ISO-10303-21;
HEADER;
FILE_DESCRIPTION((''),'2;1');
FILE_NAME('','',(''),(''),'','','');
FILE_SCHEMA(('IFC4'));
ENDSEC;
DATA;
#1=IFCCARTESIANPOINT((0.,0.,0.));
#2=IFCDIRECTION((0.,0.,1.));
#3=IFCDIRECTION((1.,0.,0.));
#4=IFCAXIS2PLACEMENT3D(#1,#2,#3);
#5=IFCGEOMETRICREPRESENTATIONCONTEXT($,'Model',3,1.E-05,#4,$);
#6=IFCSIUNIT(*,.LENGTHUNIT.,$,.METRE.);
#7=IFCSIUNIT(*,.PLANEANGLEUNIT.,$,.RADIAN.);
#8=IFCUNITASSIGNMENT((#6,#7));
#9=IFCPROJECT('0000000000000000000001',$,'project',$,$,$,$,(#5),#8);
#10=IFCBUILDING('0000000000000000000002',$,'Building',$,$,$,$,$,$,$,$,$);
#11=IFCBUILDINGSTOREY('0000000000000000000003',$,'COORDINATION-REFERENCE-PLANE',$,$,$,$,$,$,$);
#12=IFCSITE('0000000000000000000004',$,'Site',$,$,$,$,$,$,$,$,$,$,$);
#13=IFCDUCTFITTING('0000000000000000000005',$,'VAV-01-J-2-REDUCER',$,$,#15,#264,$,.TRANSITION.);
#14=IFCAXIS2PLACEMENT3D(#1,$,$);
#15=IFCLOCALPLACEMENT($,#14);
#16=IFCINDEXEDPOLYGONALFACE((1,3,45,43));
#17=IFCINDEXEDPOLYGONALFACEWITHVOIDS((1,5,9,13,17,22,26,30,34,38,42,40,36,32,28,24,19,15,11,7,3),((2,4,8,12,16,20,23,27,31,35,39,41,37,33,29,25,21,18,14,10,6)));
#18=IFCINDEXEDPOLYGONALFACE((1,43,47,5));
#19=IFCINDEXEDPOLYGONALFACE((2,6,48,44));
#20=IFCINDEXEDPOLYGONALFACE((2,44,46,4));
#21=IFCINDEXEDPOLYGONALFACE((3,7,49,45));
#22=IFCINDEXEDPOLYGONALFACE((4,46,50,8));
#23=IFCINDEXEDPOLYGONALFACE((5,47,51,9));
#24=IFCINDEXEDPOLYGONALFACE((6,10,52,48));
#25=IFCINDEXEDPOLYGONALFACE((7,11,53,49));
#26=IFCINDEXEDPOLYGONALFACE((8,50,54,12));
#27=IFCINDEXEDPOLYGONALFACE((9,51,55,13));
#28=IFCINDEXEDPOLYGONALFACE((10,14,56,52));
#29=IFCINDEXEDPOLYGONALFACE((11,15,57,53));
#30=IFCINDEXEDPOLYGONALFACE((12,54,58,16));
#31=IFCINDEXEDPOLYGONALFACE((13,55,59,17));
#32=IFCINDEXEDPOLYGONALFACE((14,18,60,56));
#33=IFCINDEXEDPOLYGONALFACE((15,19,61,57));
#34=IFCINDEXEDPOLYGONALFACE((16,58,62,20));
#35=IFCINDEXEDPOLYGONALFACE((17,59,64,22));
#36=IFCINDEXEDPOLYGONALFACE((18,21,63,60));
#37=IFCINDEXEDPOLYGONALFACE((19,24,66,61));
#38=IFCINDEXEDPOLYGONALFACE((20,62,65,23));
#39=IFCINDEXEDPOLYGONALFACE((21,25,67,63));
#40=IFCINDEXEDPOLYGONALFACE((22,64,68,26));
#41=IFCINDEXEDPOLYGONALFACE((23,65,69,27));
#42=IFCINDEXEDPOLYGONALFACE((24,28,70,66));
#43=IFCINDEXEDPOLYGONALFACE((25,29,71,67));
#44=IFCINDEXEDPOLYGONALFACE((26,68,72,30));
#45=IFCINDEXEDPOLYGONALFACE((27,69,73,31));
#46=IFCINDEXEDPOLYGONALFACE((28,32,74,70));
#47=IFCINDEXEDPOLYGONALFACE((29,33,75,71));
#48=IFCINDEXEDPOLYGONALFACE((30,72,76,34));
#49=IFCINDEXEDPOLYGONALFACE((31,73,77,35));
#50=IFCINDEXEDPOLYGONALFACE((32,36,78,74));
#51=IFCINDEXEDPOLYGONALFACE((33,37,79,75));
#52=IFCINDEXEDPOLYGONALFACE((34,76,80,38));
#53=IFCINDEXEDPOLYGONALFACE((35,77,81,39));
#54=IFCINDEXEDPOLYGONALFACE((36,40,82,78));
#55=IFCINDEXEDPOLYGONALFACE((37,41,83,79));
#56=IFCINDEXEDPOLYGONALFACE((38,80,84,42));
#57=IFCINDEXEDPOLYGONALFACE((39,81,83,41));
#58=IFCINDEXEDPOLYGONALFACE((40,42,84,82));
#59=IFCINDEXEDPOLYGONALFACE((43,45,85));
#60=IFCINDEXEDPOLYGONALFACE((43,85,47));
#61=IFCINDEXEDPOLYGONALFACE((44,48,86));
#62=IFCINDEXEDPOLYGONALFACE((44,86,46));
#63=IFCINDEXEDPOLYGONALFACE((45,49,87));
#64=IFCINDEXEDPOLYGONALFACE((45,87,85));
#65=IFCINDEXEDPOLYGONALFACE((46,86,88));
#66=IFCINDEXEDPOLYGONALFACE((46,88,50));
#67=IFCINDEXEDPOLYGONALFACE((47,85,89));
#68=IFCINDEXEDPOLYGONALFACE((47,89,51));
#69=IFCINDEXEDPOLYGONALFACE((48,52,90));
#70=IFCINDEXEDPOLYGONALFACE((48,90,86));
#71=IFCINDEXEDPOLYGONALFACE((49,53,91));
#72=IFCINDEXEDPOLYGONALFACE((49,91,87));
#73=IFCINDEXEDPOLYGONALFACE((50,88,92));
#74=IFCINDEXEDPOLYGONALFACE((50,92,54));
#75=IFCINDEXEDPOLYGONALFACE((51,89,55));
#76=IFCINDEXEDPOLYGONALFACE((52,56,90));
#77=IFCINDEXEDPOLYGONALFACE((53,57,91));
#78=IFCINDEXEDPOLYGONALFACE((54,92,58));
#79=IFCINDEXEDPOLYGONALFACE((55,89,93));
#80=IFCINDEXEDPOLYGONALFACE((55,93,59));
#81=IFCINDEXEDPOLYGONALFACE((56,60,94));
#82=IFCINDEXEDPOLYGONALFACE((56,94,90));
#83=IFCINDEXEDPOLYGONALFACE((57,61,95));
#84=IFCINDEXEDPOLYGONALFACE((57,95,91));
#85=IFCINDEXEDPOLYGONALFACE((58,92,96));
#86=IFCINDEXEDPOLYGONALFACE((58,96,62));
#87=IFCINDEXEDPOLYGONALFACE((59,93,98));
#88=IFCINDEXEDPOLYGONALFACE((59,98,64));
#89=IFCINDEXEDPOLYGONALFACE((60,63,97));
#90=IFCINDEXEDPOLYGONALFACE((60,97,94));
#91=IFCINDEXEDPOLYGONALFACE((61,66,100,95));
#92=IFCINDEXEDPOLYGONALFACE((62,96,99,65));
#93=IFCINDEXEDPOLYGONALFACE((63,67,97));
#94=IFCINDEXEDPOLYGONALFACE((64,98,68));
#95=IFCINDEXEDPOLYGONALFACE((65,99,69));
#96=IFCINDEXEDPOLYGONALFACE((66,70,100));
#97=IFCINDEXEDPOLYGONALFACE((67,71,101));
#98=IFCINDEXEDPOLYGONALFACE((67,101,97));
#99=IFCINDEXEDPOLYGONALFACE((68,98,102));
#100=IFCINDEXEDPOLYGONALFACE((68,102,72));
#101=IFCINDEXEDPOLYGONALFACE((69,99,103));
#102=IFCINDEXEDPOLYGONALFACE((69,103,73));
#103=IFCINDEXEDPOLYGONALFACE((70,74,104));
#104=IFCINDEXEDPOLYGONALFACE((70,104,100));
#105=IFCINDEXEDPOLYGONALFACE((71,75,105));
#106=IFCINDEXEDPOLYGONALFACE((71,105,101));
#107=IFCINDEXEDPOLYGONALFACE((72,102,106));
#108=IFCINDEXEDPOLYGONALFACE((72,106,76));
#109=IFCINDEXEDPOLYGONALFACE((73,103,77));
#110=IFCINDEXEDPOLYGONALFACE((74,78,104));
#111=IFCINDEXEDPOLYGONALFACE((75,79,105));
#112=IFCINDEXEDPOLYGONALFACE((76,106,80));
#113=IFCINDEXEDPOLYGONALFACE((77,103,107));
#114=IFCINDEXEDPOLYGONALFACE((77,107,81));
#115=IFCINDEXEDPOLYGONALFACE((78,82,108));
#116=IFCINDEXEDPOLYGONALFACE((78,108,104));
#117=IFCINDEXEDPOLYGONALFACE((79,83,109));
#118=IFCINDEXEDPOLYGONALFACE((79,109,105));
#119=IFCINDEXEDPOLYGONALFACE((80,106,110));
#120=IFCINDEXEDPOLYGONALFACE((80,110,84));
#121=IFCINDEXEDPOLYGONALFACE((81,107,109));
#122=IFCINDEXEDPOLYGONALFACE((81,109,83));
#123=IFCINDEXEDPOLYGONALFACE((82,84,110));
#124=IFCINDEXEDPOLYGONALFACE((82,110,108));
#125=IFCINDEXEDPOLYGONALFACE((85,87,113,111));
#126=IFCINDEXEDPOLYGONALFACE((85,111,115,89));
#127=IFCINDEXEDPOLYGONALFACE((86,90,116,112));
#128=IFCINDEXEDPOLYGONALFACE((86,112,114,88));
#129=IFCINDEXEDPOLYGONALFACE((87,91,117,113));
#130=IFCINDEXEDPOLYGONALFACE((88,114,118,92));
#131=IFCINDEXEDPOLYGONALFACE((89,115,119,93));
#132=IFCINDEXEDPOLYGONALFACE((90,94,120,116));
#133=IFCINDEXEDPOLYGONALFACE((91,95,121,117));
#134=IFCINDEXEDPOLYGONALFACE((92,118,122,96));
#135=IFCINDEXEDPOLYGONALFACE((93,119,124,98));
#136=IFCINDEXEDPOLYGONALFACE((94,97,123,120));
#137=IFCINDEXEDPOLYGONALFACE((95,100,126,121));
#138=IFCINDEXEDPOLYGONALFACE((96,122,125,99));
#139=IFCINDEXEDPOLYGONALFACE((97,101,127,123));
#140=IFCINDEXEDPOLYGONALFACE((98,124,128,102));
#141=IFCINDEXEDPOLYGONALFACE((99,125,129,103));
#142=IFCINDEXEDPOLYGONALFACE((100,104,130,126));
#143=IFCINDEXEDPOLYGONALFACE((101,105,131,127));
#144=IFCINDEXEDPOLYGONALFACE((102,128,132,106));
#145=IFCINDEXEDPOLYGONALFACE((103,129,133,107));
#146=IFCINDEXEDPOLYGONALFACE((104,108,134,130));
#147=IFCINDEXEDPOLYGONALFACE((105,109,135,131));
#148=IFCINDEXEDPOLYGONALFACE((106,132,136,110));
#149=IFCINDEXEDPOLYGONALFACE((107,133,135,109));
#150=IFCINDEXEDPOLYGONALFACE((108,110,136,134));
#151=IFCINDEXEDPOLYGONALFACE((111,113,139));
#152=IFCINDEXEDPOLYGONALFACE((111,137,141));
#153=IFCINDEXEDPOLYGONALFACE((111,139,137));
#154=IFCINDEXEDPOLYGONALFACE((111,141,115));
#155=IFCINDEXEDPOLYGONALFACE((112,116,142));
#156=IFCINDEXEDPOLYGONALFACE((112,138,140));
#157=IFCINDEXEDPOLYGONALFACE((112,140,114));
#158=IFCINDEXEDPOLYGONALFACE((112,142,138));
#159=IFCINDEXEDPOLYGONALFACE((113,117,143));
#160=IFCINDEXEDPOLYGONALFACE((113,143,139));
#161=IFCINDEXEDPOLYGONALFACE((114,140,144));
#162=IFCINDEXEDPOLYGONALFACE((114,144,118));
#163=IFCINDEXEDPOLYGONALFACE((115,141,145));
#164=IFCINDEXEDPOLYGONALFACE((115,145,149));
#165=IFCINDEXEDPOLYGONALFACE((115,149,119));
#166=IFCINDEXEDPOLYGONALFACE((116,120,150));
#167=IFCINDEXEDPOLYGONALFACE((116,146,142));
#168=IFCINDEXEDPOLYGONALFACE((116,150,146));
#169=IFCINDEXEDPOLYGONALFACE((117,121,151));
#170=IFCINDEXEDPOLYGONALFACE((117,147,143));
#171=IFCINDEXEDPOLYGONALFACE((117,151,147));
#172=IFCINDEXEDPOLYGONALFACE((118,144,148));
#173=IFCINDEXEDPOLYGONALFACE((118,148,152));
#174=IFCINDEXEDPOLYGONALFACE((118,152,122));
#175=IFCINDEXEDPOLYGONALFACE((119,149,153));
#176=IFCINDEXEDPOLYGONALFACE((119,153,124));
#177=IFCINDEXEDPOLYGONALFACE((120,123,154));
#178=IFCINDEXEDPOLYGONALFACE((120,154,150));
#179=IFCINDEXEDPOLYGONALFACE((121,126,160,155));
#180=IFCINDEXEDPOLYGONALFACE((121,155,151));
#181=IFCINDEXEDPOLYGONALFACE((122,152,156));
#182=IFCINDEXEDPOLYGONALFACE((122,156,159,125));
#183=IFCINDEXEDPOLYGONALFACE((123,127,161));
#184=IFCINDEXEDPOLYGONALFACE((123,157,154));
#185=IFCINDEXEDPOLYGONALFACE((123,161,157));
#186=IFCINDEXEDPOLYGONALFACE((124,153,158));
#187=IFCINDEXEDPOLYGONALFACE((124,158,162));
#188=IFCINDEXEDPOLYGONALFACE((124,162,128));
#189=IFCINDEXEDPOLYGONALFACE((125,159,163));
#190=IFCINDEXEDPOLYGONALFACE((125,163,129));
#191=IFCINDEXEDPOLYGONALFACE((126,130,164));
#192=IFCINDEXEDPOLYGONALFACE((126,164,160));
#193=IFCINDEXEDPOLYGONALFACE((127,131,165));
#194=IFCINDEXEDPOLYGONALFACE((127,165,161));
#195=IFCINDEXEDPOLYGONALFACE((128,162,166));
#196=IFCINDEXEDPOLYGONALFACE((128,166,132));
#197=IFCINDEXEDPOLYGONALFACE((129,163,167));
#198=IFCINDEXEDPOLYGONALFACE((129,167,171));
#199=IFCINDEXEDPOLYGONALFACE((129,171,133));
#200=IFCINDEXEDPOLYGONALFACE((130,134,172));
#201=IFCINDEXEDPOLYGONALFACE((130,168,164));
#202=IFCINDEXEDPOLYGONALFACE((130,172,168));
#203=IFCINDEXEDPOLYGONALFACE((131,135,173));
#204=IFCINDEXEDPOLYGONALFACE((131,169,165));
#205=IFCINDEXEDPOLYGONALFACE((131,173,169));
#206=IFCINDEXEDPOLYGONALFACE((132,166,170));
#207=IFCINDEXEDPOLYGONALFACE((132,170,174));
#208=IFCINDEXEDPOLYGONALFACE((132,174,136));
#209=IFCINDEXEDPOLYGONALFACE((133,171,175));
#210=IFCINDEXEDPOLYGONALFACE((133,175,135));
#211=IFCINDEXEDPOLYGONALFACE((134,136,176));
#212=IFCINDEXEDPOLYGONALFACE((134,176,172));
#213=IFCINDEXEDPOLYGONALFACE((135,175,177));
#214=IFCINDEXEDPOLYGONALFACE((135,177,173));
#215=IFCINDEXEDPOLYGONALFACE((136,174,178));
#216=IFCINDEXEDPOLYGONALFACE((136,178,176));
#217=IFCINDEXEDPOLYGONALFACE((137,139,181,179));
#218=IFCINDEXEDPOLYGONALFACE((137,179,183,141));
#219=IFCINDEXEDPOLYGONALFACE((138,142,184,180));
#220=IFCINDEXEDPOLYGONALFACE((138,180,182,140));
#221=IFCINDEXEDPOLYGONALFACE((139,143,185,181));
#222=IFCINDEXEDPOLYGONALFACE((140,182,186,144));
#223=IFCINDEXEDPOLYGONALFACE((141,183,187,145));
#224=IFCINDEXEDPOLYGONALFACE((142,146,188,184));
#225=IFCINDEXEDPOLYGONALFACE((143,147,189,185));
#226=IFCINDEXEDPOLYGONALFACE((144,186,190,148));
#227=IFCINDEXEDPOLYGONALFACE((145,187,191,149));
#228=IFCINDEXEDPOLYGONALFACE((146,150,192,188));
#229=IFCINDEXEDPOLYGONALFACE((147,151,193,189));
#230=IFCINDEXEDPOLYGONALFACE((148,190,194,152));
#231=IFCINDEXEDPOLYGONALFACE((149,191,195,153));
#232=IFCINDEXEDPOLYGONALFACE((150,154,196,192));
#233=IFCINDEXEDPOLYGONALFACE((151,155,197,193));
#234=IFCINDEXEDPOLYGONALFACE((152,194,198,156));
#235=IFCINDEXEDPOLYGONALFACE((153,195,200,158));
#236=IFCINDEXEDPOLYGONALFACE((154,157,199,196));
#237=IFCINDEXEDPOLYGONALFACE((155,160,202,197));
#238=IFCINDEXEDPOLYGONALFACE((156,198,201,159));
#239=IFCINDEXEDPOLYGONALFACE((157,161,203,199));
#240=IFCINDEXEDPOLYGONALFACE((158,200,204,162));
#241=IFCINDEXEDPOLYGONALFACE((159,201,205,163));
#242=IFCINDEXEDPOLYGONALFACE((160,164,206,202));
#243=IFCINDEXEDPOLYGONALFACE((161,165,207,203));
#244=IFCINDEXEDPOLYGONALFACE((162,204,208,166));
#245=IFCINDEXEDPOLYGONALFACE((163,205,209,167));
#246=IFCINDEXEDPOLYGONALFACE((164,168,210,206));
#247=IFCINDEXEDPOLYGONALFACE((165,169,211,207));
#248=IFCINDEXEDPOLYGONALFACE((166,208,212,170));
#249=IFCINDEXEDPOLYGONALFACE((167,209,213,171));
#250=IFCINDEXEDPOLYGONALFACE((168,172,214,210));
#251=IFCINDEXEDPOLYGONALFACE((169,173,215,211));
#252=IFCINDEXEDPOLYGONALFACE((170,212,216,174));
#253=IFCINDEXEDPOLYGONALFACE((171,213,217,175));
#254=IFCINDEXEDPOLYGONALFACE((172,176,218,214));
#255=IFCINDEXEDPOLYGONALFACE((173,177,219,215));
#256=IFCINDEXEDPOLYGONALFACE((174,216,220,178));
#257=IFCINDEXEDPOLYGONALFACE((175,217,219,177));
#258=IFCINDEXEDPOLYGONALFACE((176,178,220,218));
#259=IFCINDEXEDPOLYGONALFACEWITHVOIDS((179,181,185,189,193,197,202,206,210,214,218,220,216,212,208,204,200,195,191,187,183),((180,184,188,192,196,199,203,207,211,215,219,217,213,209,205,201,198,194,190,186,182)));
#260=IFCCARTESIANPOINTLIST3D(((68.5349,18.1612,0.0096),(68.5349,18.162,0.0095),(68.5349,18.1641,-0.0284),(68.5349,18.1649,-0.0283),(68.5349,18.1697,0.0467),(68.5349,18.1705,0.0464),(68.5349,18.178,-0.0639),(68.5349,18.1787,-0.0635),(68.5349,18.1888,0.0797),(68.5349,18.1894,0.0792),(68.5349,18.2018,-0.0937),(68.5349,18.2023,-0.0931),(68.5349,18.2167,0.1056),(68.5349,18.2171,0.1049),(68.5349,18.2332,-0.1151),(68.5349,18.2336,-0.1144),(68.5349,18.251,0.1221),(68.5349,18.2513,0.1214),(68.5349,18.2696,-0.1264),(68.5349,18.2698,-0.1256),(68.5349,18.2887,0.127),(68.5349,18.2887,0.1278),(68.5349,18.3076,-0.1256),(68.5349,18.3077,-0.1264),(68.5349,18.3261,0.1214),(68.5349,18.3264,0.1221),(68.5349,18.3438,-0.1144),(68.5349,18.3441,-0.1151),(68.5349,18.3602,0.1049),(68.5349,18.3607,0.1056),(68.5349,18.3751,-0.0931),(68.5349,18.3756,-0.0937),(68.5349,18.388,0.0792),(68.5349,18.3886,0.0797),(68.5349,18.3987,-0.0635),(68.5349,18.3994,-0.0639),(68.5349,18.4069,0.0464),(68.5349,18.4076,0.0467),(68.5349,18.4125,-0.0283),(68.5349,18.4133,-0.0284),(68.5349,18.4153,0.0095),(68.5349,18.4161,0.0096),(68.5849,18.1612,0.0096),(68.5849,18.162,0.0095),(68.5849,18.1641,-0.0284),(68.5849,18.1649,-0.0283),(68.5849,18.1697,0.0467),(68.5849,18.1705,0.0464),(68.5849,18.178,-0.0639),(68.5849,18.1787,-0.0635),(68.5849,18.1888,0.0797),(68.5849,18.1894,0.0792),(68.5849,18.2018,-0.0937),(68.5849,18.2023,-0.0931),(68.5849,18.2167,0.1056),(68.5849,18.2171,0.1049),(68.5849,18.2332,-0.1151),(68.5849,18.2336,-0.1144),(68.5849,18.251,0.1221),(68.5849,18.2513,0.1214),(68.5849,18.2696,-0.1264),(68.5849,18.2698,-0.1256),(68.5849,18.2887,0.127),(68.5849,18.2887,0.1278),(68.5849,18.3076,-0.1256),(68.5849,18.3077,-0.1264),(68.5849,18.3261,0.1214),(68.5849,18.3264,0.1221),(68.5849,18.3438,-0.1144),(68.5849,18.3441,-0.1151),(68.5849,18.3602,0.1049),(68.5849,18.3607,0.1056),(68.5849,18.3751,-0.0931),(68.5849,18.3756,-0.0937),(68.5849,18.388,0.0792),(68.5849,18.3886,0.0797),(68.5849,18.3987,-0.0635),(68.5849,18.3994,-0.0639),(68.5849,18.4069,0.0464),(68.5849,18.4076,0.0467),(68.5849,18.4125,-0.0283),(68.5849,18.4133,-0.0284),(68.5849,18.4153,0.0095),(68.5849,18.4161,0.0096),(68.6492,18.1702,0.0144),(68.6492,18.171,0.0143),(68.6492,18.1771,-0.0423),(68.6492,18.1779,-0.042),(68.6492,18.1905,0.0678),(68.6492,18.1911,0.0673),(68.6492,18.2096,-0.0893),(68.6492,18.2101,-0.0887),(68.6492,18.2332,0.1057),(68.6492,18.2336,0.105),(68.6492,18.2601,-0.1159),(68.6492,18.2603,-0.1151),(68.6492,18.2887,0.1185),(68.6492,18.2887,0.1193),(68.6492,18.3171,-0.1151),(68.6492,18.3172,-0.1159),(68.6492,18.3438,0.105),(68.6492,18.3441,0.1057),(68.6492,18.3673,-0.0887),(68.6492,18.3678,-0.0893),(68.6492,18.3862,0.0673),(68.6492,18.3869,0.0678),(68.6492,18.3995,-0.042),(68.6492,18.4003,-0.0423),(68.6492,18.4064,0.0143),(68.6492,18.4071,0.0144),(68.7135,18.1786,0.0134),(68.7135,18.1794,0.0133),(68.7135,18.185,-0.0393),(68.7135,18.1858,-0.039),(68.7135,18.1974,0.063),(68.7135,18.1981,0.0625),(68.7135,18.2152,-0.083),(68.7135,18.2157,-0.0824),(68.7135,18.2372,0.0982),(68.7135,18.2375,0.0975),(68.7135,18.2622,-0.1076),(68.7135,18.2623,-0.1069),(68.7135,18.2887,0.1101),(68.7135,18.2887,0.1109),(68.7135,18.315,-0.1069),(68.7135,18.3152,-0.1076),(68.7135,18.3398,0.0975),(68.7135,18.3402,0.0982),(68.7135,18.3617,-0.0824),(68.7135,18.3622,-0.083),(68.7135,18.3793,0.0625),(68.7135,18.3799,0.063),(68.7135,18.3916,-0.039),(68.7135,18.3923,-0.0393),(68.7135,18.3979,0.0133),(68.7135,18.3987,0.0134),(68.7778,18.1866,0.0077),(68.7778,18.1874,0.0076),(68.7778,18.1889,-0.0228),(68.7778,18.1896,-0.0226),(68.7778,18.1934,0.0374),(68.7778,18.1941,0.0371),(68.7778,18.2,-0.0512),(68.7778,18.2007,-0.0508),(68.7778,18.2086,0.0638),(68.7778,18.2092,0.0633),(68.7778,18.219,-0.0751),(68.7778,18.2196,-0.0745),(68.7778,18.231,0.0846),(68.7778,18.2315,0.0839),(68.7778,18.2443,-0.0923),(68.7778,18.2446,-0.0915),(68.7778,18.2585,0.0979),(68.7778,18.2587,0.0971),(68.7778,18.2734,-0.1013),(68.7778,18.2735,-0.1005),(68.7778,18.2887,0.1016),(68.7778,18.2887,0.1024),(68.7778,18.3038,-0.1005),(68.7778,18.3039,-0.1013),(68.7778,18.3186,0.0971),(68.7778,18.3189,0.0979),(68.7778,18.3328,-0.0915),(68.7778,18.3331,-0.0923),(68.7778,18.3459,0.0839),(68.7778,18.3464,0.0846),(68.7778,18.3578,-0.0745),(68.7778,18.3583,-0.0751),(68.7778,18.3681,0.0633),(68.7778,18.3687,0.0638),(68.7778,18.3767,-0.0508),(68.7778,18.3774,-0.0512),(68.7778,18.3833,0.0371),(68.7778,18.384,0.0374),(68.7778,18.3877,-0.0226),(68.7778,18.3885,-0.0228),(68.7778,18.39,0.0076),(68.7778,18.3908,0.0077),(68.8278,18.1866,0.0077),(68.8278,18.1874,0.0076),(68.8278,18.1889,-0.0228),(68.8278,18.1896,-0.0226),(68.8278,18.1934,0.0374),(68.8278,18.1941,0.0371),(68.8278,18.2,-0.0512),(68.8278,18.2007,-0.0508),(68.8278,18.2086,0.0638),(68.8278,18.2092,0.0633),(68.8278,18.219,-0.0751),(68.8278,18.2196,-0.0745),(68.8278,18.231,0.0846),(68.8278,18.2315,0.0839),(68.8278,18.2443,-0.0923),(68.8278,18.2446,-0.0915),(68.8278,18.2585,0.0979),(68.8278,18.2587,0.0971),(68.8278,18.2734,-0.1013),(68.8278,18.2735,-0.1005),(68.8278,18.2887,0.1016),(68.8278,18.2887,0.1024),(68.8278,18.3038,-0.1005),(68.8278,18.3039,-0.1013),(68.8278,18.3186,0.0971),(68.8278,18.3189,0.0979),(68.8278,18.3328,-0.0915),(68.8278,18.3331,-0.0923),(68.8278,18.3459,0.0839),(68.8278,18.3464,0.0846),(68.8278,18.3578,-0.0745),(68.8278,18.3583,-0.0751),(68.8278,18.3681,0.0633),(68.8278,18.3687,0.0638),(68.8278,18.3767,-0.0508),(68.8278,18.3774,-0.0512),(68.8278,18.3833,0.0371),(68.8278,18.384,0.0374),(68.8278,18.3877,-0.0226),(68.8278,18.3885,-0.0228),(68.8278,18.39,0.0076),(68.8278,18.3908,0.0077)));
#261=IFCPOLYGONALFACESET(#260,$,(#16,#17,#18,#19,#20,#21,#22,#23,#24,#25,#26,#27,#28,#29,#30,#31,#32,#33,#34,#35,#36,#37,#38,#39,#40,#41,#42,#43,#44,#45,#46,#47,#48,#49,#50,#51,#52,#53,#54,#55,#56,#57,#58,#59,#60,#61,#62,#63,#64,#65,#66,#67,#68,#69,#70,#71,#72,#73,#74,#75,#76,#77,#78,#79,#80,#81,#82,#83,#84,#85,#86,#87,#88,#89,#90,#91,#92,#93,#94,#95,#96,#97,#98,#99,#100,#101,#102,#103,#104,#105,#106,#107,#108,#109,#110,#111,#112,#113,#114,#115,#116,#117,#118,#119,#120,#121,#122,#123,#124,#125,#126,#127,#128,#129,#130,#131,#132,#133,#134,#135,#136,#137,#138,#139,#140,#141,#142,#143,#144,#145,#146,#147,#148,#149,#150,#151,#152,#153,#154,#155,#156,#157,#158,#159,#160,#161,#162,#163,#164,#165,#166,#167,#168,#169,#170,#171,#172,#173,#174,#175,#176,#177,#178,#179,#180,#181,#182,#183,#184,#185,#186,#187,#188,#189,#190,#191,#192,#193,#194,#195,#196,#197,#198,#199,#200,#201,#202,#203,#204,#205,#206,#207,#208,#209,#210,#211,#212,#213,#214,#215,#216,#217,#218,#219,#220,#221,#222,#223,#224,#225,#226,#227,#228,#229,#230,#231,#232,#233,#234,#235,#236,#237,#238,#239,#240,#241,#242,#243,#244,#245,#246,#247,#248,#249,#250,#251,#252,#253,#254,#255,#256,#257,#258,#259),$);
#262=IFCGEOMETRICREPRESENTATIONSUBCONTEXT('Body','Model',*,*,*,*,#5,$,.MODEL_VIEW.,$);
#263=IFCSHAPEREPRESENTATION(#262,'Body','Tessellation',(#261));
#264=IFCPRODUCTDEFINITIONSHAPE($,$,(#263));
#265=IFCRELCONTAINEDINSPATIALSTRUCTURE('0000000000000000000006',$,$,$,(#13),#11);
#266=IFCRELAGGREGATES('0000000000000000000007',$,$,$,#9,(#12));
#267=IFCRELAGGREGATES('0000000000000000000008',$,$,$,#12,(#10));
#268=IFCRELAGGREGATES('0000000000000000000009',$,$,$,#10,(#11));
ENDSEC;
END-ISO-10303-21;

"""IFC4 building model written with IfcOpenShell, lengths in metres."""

from ifc_helpers import new_model, entity, si_unit, frame, origin_with_axes, place, context, subcontext, project, spatial, element, save


model = new_model("IFC4")

# Units and contexts
model_context = context("Model", 3, precision=1e-05, world=origin_with_axes())
body_context_1 = subcontext(model_context, "Body", "Model", "MODEL_VIEW")
ifc_project = project(units=[si_unit("LENGTHUNIT", "METRE"), si_unit("PLANEANGLEUNIT", "RADIAN")], contexts=[model_context])

# Site, building, storey
site = spatial("IfcSite", under=ifc_project, Name="Site")
building = spatial("IfcBuilding", under=site, Name="Building")
storey = spatial("IfcBuildingStorey", under=building, Name="COORDINATION-REFERENCE-PLANE")

# Duct fitting
for number, where, z_axis, x_axis, name in (
    (1, (68.5349, 18.2887, 0.0), (0.0, 1.0, 0.0), (0.0, 0.0, 1.0), "VAV-01-J-2-REDUCER"),
):
    element("IfcDuctFitting", number, at=place(None, frame(where, z_axis=z_axis, x_axis=x_axis)), inside=storey, Name=name, PredefinedType="TRANSITION", context=body_context_1, shape_type="SweptSolid", body=[
        entity("IfcRevolvedAreaSolid", entity("IfcArbitraryClosedProfileDef", "AREA", None, entity("IfcPolyline", [entity("IfcCartesianPoint", [0.1278, 0.0]), entity("IfcCartesianPoint", [0.1278, 0.05]), entity("IfcCartesianPoint", [0.1024, 0.2429]), entity("IfcCartesianPoint", [0.1024, 0.2929]), entity("IfcCartesianPoint", [0.1016, 0.2929]), entity("IfcCartesianPoint", [0.1016, 0.2429]), entity("IfcCartesianPoint", [0.127, 0.05]), entity("IfcCartesianPoint", [0.127, 0.0]), entity("IfcCartesianPoint", [0.1278, 0.0])])), entity("IfcAxis2Placement3D", entity("IfcCartesianPoint", [0.0, 0.0, 0.0])), entity("IfcAxis1Placement", entity("IfcCartesianPoint", [0.0, 0.0, 0.0]), entity("IfcDirection", [0.0, 1.0, 0.0])), 6.283185),
    ])

save(model, "model.ifc")
